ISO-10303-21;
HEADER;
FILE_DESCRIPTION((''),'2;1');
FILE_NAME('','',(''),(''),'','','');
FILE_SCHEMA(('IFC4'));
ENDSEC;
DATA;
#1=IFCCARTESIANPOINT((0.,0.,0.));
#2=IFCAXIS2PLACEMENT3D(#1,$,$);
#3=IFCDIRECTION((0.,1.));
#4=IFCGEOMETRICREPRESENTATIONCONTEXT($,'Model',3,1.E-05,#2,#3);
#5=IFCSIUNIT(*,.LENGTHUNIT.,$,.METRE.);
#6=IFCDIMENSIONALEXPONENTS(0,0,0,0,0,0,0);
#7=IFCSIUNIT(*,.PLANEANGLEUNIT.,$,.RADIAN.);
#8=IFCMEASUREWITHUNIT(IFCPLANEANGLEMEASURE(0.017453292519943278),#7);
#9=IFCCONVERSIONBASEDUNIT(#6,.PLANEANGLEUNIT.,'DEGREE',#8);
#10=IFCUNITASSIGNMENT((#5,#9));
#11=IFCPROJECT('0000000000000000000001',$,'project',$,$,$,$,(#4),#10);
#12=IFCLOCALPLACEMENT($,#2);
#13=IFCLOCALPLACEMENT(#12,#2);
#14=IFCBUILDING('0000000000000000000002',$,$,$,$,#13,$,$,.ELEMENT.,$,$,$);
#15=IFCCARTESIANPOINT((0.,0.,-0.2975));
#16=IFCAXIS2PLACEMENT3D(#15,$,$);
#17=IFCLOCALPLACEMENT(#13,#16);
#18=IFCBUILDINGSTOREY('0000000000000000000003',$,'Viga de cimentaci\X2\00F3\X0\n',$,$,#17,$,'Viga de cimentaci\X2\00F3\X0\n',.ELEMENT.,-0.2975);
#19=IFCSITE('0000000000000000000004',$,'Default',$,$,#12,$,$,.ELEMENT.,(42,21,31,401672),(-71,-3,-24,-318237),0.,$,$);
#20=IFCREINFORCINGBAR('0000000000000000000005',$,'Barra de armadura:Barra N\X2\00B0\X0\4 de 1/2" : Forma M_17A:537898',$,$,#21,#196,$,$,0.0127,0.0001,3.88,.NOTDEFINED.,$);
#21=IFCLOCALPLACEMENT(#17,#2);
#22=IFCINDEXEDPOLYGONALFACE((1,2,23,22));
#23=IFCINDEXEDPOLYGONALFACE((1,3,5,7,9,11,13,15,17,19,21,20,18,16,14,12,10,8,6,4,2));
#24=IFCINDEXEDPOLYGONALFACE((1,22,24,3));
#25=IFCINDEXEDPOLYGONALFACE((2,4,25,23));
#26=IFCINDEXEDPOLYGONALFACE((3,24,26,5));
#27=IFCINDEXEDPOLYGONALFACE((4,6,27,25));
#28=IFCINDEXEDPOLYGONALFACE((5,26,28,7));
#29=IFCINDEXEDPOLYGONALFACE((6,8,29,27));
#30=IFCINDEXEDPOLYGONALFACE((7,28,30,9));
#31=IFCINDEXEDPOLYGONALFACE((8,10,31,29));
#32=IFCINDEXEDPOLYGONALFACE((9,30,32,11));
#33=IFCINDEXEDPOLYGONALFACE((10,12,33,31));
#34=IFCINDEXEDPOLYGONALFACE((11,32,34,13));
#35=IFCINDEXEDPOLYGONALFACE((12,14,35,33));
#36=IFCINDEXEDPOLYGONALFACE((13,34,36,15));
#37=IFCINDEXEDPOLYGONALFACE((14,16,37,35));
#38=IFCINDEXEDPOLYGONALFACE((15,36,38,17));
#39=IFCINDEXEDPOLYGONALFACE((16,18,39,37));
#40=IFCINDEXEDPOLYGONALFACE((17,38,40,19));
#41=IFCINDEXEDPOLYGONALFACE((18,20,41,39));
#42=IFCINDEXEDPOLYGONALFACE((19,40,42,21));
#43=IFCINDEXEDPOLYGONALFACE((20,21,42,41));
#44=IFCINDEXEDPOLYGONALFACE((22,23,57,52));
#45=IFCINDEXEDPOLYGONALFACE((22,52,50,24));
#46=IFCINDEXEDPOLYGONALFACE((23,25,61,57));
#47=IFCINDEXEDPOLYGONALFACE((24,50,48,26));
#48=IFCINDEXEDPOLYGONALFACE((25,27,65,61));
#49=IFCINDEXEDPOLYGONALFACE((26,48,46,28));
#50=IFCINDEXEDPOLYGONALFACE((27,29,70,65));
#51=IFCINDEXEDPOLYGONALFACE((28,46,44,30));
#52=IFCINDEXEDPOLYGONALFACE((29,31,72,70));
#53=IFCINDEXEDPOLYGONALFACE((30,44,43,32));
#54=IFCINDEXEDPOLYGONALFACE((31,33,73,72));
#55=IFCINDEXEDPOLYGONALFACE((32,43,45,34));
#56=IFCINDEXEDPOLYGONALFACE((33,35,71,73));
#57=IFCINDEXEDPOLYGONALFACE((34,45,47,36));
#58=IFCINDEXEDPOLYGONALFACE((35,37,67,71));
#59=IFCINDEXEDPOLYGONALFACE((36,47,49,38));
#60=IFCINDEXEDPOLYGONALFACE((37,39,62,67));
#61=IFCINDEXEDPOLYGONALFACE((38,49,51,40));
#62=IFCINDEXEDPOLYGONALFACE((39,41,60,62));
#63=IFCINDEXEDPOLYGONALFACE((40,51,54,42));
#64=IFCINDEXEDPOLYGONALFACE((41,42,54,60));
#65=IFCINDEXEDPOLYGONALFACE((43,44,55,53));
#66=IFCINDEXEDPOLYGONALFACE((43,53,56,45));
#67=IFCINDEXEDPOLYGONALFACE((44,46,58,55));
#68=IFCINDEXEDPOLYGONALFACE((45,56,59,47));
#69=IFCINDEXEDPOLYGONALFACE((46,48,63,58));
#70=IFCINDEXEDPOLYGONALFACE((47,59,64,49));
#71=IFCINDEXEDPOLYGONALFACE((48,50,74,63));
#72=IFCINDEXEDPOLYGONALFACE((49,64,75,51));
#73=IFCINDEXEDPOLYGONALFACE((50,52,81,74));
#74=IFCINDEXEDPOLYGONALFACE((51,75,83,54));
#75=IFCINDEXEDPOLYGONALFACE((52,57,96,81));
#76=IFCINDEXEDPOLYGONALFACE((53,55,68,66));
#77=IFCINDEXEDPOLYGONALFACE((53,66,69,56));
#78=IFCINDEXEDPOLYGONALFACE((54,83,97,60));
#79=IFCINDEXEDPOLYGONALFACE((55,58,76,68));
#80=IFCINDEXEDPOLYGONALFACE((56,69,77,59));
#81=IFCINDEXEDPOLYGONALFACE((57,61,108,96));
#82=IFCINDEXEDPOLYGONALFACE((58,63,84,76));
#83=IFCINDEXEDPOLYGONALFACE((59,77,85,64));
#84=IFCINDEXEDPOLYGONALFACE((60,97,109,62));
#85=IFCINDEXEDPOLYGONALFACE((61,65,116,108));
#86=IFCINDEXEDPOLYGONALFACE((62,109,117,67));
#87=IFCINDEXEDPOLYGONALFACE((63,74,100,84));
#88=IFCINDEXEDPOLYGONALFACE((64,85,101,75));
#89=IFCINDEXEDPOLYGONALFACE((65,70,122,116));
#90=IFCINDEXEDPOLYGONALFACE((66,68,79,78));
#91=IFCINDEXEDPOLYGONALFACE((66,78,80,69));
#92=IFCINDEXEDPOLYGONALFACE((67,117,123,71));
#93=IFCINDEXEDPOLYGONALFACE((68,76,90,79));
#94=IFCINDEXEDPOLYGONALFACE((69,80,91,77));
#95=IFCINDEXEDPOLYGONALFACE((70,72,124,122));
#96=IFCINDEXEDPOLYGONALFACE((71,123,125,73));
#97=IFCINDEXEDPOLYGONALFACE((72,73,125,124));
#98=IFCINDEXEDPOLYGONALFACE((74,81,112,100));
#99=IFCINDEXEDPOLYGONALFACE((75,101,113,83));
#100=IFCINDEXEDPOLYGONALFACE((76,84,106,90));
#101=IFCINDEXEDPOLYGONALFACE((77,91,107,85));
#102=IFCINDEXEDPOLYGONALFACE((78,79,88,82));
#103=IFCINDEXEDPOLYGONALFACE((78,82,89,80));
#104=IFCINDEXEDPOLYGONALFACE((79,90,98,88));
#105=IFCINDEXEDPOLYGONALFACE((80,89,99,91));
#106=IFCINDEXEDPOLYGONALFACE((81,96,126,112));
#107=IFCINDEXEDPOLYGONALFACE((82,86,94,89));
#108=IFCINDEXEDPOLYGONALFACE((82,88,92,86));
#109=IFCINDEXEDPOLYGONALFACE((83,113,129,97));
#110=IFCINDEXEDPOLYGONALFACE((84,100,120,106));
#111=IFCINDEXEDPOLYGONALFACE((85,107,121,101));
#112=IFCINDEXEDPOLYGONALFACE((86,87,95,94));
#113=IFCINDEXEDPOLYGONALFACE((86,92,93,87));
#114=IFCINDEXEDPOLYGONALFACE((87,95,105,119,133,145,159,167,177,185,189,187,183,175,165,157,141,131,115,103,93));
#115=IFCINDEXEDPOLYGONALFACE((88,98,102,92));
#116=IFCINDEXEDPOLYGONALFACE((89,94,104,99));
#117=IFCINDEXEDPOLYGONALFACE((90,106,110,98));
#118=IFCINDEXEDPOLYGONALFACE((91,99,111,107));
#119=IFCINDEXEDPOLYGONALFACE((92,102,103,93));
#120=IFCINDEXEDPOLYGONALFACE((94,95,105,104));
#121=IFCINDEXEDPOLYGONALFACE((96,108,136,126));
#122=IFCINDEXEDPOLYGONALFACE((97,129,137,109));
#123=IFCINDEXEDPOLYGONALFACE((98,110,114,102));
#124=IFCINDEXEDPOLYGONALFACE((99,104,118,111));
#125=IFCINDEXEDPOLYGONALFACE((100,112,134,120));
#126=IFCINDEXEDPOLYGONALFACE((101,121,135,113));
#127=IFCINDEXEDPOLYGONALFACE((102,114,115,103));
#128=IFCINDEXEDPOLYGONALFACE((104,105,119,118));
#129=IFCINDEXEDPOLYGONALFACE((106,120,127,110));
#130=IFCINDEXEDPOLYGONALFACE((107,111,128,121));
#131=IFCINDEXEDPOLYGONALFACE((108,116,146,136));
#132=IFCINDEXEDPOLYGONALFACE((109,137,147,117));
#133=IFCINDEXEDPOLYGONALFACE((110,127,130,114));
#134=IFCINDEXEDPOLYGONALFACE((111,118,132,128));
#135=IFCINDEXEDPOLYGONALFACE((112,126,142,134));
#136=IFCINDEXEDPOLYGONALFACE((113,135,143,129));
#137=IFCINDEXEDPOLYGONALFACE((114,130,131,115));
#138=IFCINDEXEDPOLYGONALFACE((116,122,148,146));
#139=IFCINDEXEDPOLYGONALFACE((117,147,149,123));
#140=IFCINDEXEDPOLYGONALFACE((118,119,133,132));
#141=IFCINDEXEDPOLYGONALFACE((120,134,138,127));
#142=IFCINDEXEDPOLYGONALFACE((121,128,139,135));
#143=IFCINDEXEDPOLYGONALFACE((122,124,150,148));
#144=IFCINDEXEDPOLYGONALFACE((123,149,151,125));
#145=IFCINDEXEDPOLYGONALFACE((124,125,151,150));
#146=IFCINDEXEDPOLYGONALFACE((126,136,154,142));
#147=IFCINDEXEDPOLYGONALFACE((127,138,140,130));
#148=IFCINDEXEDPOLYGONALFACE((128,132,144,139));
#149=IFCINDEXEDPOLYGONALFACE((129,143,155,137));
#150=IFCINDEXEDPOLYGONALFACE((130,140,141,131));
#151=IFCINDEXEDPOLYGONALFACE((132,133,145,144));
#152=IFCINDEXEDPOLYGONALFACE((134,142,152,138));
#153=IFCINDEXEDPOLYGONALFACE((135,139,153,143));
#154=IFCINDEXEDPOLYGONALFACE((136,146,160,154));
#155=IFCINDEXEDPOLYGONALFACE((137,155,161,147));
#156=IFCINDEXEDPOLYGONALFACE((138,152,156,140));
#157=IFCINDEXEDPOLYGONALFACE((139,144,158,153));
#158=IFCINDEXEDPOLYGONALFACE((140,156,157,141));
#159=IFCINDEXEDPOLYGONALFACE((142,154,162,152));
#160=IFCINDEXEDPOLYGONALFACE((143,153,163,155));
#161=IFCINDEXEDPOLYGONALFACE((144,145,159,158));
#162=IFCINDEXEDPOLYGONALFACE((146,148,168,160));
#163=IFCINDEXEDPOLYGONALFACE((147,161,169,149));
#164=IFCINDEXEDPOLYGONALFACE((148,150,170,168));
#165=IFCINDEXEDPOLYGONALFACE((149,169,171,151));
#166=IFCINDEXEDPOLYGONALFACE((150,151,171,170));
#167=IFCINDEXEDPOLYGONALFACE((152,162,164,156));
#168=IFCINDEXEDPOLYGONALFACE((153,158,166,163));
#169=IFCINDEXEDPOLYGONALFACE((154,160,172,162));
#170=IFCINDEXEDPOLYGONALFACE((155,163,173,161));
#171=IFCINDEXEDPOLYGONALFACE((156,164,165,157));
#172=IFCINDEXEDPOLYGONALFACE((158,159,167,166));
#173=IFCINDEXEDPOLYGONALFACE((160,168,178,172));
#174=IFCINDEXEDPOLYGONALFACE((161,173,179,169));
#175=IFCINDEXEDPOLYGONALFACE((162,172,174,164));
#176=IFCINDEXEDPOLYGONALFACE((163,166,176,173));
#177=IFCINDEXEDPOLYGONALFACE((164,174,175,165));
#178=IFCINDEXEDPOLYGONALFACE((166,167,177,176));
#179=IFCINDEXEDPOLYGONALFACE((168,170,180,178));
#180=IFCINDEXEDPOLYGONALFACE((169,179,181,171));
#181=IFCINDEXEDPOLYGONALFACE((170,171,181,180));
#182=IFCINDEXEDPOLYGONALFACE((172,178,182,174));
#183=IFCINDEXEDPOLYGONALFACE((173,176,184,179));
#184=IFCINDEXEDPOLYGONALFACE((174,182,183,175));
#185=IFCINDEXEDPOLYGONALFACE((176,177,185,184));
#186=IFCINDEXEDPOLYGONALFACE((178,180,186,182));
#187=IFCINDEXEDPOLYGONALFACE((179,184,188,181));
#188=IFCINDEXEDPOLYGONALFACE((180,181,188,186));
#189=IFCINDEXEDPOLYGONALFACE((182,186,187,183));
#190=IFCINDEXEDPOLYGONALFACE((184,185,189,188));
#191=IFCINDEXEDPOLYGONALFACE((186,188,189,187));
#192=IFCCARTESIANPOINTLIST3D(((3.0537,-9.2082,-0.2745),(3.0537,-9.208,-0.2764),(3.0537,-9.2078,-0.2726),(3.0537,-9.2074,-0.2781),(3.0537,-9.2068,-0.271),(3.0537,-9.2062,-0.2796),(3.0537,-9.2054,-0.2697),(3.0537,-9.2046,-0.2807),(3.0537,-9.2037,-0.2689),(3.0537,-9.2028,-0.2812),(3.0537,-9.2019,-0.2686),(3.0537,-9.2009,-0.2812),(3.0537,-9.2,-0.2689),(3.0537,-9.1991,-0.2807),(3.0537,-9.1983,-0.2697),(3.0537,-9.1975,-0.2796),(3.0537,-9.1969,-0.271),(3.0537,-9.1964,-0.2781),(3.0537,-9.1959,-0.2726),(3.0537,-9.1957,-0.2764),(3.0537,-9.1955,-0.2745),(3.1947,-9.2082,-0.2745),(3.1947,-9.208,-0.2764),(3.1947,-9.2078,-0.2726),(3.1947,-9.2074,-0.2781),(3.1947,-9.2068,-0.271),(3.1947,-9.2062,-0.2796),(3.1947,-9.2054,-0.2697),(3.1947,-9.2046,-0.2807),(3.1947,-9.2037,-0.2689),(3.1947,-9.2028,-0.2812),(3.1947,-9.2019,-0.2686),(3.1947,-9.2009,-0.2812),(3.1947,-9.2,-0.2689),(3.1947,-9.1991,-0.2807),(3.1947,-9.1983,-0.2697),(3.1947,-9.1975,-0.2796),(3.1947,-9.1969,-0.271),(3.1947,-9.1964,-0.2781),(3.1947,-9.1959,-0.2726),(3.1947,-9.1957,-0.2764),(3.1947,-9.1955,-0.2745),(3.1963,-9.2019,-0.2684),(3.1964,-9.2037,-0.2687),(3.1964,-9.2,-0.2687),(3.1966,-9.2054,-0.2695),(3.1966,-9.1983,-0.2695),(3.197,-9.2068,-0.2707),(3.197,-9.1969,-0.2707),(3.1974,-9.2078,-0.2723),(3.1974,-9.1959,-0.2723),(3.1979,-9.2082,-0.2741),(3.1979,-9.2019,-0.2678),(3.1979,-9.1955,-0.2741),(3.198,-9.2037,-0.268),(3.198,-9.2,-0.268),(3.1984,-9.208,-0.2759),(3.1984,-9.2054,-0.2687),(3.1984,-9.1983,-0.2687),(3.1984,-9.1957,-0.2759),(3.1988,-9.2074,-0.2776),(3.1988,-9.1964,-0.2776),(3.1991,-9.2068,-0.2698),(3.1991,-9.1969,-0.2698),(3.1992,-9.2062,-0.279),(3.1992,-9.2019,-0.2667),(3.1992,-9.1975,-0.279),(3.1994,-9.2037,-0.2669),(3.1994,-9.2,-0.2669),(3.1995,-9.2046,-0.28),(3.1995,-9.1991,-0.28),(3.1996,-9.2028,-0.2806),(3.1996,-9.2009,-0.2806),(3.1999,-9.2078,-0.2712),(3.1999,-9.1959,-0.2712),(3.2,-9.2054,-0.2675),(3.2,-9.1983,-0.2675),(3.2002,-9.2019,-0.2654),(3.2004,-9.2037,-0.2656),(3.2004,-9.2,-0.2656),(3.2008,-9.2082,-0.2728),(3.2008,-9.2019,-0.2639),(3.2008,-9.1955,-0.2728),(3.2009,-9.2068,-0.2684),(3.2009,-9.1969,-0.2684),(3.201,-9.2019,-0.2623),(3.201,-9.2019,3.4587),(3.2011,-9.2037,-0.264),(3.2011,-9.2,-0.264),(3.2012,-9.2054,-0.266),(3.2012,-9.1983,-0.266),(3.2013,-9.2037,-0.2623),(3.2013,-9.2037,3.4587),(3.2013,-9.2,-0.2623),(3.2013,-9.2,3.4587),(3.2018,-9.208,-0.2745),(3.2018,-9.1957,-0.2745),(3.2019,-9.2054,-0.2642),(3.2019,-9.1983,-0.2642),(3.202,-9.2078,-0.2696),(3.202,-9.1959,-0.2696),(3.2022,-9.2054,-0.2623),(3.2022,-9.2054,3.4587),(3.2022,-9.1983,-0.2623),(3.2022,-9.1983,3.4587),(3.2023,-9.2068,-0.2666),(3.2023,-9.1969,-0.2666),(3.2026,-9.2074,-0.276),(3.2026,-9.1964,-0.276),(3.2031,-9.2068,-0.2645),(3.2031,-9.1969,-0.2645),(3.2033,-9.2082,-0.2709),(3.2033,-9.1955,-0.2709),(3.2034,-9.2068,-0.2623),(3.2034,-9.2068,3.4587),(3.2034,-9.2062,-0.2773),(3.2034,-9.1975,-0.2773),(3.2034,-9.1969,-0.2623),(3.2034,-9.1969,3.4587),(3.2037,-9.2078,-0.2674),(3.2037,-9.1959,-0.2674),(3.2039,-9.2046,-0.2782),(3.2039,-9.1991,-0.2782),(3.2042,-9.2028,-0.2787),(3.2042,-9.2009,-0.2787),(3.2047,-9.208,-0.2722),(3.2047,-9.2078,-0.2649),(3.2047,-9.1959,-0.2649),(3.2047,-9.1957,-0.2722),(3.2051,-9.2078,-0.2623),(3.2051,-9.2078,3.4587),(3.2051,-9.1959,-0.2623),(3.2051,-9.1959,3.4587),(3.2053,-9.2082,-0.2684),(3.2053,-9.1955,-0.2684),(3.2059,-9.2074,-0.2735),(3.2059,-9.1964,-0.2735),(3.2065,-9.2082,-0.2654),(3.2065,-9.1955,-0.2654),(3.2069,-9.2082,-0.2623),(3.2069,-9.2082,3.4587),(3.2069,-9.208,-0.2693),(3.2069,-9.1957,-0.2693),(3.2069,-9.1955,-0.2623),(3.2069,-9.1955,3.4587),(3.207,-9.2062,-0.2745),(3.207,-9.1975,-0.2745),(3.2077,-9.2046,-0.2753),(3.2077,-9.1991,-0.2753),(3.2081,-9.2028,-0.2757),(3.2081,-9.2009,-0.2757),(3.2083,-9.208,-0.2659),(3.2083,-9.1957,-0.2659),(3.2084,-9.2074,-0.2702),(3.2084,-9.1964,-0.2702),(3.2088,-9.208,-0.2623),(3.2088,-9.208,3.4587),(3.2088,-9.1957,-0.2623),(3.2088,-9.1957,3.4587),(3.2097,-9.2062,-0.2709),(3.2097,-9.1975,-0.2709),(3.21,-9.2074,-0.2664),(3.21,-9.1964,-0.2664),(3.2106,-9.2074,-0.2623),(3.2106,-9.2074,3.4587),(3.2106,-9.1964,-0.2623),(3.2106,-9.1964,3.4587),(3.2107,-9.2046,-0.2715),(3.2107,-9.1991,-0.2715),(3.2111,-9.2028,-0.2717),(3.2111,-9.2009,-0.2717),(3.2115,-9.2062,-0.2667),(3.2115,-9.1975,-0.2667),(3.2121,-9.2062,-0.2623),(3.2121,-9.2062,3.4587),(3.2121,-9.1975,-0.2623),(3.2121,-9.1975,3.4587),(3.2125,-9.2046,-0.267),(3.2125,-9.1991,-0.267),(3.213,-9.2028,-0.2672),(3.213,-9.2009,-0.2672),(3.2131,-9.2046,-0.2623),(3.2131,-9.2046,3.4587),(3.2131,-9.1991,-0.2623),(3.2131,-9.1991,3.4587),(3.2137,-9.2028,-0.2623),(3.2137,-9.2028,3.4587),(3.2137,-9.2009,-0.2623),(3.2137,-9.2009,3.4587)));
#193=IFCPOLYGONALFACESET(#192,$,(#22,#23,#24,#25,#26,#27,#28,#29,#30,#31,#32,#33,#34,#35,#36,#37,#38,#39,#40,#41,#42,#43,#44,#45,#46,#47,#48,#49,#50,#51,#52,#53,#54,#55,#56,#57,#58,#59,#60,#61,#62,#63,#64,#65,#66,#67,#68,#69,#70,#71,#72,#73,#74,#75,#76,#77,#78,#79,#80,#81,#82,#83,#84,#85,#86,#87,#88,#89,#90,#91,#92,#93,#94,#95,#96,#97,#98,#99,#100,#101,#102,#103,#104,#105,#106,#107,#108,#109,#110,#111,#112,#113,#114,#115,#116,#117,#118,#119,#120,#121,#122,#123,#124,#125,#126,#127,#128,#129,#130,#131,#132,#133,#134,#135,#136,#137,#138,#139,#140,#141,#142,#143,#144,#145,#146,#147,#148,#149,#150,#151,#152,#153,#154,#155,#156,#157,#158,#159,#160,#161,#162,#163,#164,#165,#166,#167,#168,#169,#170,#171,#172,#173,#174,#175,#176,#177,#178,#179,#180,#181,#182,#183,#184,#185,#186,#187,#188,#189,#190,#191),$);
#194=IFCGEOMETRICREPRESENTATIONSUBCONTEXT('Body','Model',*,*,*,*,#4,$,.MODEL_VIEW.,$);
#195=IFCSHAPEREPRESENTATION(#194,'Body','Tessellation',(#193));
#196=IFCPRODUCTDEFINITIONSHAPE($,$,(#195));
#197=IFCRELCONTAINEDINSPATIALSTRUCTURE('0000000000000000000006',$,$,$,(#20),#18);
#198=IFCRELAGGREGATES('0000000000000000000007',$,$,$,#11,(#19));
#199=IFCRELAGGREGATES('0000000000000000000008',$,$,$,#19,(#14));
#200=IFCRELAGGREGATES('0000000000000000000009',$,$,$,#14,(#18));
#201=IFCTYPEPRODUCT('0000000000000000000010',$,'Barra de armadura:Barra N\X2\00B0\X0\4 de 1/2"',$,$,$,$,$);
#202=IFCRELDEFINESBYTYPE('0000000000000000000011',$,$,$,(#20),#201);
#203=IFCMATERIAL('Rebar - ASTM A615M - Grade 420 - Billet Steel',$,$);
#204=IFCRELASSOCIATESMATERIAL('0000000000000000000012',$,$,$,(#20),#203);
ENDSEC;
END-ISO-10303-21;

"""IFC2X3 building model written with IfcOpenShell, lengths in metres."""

from ifc_helpers import new_model, entity, si_unit, converted_unit, direction, frame, origin, place, context, subcontext, project, spatial, material, type_object, element, save


model = new_model("IFC2X3")

# Units and contexts
model_context = context("Model", 3, precision=1e-05, world=origin(), true_north=direction((0.0, 1.0)))
body_context = subcontext(model_context, "Body", "Model", "MODEL_VIEW")
ifc_project = project(units=[si_unit("LENGTHUNIT", "METRE"), converted_unit("PLANEANGLEUNIT", "DEGREE", entity("IfcPlaneAngleMeasure", 0.017453292519943278), si_unit("PLANEANGLEUNIT", "RADIAN"), dimensions=[0, 0, 0, 0, 0, 0, 0])], contexts=[model_context])

# Site, building, storey
site_placement = place(None, origin())
site = spatial("IfcSite", under=ifc_project, at=site_placement, Name="Default", CompositionType="ELEMENT", RefLatitude=(42, 21, 31, 401672), RefLongitude=(-71, -3, -24, -318237), RefElevation=0.0)
building_placement = place(site_placement, origin())
building = spatial("IfcBuilding", under=site, at=building_placement, CompositionType="ELEMENT")
storey_placement = place(building_placement, frame((0.0, 0.0, -0.2975)))
storey = spatial("IfcBuildingStorey", under=building, at=storey_placement, Name="Viga de cimentación", LongName="Viga de cimentación", CompositionType="ELEMENT", Elevation=-0.2975)

# Reinforcing bar
ifc_material = material(Name="Rebar - ASTM A615M - Grade 420 - Billet Steel")
type_product_1 = type_object("IfcTypeProduct", Name="Barra de armadura:Barra N°4 de 1/2\"")
reinforcing_bar_1_placement = place(storey_placement, origin())
element("IfcReinforcingBar", 1, at=reinforcing_bar_1_placement, inside=storey, type_object=type_product_1, material=ifc_material, Name="Barra de armadura:Barra N°4 de 1/2\" : Forma M_17A:537898", BarLength=3.88, BarRole="NOTDEFINED", CrossSectionArea=0.0001, NominalDiameter=0.0127, context=body_context, shape_type="AdvancedSweptSolid", body=[
    entity("IfcSweptDiskSolid", entity("IfcCompositeCurve", [entity("IfcCompositeCurveSegment", "CONTINUOUS", True, entity("IfcPolyline", [entity("IfcCartesianPoint", [3.2074, -9.2019, 3.4587]), entity("IfcCartesianPoint", [3.2074, -9.2019, -0.2623])])), entity("IfcCompositeCurveSegment", "CONTINUOUS", True, entity("IfcTrimmedCurve", entity("IfcCircle", entity("IfcAxis2Placement3D", entity("IfcCartesianPoint", [3.1947, -9.2019, -0.2623]), entity("IfcDirection", [0.0, 1.0, 0.0]), entity("IfcDirection", [0.0, 0.0, -1.0])), 0.0127), [entity("IfcParameterValue", 270.0)], [entity("IfcParameterValue", 360.0)], True, "PARAMETER")), entity("IfcCompositeCurveSegment", "CONTINUOUS", True, entity("IfcPolyline", [entity("IfcCartesianPoint", [3.1947, -9.2019, -0.275]), entity("IfcCartesianPoint", [3.0537, -9.2019, -0.275])]))], False), 0.0063, None, 0.0, 92.0),
])

save(model, "model.ifc")
